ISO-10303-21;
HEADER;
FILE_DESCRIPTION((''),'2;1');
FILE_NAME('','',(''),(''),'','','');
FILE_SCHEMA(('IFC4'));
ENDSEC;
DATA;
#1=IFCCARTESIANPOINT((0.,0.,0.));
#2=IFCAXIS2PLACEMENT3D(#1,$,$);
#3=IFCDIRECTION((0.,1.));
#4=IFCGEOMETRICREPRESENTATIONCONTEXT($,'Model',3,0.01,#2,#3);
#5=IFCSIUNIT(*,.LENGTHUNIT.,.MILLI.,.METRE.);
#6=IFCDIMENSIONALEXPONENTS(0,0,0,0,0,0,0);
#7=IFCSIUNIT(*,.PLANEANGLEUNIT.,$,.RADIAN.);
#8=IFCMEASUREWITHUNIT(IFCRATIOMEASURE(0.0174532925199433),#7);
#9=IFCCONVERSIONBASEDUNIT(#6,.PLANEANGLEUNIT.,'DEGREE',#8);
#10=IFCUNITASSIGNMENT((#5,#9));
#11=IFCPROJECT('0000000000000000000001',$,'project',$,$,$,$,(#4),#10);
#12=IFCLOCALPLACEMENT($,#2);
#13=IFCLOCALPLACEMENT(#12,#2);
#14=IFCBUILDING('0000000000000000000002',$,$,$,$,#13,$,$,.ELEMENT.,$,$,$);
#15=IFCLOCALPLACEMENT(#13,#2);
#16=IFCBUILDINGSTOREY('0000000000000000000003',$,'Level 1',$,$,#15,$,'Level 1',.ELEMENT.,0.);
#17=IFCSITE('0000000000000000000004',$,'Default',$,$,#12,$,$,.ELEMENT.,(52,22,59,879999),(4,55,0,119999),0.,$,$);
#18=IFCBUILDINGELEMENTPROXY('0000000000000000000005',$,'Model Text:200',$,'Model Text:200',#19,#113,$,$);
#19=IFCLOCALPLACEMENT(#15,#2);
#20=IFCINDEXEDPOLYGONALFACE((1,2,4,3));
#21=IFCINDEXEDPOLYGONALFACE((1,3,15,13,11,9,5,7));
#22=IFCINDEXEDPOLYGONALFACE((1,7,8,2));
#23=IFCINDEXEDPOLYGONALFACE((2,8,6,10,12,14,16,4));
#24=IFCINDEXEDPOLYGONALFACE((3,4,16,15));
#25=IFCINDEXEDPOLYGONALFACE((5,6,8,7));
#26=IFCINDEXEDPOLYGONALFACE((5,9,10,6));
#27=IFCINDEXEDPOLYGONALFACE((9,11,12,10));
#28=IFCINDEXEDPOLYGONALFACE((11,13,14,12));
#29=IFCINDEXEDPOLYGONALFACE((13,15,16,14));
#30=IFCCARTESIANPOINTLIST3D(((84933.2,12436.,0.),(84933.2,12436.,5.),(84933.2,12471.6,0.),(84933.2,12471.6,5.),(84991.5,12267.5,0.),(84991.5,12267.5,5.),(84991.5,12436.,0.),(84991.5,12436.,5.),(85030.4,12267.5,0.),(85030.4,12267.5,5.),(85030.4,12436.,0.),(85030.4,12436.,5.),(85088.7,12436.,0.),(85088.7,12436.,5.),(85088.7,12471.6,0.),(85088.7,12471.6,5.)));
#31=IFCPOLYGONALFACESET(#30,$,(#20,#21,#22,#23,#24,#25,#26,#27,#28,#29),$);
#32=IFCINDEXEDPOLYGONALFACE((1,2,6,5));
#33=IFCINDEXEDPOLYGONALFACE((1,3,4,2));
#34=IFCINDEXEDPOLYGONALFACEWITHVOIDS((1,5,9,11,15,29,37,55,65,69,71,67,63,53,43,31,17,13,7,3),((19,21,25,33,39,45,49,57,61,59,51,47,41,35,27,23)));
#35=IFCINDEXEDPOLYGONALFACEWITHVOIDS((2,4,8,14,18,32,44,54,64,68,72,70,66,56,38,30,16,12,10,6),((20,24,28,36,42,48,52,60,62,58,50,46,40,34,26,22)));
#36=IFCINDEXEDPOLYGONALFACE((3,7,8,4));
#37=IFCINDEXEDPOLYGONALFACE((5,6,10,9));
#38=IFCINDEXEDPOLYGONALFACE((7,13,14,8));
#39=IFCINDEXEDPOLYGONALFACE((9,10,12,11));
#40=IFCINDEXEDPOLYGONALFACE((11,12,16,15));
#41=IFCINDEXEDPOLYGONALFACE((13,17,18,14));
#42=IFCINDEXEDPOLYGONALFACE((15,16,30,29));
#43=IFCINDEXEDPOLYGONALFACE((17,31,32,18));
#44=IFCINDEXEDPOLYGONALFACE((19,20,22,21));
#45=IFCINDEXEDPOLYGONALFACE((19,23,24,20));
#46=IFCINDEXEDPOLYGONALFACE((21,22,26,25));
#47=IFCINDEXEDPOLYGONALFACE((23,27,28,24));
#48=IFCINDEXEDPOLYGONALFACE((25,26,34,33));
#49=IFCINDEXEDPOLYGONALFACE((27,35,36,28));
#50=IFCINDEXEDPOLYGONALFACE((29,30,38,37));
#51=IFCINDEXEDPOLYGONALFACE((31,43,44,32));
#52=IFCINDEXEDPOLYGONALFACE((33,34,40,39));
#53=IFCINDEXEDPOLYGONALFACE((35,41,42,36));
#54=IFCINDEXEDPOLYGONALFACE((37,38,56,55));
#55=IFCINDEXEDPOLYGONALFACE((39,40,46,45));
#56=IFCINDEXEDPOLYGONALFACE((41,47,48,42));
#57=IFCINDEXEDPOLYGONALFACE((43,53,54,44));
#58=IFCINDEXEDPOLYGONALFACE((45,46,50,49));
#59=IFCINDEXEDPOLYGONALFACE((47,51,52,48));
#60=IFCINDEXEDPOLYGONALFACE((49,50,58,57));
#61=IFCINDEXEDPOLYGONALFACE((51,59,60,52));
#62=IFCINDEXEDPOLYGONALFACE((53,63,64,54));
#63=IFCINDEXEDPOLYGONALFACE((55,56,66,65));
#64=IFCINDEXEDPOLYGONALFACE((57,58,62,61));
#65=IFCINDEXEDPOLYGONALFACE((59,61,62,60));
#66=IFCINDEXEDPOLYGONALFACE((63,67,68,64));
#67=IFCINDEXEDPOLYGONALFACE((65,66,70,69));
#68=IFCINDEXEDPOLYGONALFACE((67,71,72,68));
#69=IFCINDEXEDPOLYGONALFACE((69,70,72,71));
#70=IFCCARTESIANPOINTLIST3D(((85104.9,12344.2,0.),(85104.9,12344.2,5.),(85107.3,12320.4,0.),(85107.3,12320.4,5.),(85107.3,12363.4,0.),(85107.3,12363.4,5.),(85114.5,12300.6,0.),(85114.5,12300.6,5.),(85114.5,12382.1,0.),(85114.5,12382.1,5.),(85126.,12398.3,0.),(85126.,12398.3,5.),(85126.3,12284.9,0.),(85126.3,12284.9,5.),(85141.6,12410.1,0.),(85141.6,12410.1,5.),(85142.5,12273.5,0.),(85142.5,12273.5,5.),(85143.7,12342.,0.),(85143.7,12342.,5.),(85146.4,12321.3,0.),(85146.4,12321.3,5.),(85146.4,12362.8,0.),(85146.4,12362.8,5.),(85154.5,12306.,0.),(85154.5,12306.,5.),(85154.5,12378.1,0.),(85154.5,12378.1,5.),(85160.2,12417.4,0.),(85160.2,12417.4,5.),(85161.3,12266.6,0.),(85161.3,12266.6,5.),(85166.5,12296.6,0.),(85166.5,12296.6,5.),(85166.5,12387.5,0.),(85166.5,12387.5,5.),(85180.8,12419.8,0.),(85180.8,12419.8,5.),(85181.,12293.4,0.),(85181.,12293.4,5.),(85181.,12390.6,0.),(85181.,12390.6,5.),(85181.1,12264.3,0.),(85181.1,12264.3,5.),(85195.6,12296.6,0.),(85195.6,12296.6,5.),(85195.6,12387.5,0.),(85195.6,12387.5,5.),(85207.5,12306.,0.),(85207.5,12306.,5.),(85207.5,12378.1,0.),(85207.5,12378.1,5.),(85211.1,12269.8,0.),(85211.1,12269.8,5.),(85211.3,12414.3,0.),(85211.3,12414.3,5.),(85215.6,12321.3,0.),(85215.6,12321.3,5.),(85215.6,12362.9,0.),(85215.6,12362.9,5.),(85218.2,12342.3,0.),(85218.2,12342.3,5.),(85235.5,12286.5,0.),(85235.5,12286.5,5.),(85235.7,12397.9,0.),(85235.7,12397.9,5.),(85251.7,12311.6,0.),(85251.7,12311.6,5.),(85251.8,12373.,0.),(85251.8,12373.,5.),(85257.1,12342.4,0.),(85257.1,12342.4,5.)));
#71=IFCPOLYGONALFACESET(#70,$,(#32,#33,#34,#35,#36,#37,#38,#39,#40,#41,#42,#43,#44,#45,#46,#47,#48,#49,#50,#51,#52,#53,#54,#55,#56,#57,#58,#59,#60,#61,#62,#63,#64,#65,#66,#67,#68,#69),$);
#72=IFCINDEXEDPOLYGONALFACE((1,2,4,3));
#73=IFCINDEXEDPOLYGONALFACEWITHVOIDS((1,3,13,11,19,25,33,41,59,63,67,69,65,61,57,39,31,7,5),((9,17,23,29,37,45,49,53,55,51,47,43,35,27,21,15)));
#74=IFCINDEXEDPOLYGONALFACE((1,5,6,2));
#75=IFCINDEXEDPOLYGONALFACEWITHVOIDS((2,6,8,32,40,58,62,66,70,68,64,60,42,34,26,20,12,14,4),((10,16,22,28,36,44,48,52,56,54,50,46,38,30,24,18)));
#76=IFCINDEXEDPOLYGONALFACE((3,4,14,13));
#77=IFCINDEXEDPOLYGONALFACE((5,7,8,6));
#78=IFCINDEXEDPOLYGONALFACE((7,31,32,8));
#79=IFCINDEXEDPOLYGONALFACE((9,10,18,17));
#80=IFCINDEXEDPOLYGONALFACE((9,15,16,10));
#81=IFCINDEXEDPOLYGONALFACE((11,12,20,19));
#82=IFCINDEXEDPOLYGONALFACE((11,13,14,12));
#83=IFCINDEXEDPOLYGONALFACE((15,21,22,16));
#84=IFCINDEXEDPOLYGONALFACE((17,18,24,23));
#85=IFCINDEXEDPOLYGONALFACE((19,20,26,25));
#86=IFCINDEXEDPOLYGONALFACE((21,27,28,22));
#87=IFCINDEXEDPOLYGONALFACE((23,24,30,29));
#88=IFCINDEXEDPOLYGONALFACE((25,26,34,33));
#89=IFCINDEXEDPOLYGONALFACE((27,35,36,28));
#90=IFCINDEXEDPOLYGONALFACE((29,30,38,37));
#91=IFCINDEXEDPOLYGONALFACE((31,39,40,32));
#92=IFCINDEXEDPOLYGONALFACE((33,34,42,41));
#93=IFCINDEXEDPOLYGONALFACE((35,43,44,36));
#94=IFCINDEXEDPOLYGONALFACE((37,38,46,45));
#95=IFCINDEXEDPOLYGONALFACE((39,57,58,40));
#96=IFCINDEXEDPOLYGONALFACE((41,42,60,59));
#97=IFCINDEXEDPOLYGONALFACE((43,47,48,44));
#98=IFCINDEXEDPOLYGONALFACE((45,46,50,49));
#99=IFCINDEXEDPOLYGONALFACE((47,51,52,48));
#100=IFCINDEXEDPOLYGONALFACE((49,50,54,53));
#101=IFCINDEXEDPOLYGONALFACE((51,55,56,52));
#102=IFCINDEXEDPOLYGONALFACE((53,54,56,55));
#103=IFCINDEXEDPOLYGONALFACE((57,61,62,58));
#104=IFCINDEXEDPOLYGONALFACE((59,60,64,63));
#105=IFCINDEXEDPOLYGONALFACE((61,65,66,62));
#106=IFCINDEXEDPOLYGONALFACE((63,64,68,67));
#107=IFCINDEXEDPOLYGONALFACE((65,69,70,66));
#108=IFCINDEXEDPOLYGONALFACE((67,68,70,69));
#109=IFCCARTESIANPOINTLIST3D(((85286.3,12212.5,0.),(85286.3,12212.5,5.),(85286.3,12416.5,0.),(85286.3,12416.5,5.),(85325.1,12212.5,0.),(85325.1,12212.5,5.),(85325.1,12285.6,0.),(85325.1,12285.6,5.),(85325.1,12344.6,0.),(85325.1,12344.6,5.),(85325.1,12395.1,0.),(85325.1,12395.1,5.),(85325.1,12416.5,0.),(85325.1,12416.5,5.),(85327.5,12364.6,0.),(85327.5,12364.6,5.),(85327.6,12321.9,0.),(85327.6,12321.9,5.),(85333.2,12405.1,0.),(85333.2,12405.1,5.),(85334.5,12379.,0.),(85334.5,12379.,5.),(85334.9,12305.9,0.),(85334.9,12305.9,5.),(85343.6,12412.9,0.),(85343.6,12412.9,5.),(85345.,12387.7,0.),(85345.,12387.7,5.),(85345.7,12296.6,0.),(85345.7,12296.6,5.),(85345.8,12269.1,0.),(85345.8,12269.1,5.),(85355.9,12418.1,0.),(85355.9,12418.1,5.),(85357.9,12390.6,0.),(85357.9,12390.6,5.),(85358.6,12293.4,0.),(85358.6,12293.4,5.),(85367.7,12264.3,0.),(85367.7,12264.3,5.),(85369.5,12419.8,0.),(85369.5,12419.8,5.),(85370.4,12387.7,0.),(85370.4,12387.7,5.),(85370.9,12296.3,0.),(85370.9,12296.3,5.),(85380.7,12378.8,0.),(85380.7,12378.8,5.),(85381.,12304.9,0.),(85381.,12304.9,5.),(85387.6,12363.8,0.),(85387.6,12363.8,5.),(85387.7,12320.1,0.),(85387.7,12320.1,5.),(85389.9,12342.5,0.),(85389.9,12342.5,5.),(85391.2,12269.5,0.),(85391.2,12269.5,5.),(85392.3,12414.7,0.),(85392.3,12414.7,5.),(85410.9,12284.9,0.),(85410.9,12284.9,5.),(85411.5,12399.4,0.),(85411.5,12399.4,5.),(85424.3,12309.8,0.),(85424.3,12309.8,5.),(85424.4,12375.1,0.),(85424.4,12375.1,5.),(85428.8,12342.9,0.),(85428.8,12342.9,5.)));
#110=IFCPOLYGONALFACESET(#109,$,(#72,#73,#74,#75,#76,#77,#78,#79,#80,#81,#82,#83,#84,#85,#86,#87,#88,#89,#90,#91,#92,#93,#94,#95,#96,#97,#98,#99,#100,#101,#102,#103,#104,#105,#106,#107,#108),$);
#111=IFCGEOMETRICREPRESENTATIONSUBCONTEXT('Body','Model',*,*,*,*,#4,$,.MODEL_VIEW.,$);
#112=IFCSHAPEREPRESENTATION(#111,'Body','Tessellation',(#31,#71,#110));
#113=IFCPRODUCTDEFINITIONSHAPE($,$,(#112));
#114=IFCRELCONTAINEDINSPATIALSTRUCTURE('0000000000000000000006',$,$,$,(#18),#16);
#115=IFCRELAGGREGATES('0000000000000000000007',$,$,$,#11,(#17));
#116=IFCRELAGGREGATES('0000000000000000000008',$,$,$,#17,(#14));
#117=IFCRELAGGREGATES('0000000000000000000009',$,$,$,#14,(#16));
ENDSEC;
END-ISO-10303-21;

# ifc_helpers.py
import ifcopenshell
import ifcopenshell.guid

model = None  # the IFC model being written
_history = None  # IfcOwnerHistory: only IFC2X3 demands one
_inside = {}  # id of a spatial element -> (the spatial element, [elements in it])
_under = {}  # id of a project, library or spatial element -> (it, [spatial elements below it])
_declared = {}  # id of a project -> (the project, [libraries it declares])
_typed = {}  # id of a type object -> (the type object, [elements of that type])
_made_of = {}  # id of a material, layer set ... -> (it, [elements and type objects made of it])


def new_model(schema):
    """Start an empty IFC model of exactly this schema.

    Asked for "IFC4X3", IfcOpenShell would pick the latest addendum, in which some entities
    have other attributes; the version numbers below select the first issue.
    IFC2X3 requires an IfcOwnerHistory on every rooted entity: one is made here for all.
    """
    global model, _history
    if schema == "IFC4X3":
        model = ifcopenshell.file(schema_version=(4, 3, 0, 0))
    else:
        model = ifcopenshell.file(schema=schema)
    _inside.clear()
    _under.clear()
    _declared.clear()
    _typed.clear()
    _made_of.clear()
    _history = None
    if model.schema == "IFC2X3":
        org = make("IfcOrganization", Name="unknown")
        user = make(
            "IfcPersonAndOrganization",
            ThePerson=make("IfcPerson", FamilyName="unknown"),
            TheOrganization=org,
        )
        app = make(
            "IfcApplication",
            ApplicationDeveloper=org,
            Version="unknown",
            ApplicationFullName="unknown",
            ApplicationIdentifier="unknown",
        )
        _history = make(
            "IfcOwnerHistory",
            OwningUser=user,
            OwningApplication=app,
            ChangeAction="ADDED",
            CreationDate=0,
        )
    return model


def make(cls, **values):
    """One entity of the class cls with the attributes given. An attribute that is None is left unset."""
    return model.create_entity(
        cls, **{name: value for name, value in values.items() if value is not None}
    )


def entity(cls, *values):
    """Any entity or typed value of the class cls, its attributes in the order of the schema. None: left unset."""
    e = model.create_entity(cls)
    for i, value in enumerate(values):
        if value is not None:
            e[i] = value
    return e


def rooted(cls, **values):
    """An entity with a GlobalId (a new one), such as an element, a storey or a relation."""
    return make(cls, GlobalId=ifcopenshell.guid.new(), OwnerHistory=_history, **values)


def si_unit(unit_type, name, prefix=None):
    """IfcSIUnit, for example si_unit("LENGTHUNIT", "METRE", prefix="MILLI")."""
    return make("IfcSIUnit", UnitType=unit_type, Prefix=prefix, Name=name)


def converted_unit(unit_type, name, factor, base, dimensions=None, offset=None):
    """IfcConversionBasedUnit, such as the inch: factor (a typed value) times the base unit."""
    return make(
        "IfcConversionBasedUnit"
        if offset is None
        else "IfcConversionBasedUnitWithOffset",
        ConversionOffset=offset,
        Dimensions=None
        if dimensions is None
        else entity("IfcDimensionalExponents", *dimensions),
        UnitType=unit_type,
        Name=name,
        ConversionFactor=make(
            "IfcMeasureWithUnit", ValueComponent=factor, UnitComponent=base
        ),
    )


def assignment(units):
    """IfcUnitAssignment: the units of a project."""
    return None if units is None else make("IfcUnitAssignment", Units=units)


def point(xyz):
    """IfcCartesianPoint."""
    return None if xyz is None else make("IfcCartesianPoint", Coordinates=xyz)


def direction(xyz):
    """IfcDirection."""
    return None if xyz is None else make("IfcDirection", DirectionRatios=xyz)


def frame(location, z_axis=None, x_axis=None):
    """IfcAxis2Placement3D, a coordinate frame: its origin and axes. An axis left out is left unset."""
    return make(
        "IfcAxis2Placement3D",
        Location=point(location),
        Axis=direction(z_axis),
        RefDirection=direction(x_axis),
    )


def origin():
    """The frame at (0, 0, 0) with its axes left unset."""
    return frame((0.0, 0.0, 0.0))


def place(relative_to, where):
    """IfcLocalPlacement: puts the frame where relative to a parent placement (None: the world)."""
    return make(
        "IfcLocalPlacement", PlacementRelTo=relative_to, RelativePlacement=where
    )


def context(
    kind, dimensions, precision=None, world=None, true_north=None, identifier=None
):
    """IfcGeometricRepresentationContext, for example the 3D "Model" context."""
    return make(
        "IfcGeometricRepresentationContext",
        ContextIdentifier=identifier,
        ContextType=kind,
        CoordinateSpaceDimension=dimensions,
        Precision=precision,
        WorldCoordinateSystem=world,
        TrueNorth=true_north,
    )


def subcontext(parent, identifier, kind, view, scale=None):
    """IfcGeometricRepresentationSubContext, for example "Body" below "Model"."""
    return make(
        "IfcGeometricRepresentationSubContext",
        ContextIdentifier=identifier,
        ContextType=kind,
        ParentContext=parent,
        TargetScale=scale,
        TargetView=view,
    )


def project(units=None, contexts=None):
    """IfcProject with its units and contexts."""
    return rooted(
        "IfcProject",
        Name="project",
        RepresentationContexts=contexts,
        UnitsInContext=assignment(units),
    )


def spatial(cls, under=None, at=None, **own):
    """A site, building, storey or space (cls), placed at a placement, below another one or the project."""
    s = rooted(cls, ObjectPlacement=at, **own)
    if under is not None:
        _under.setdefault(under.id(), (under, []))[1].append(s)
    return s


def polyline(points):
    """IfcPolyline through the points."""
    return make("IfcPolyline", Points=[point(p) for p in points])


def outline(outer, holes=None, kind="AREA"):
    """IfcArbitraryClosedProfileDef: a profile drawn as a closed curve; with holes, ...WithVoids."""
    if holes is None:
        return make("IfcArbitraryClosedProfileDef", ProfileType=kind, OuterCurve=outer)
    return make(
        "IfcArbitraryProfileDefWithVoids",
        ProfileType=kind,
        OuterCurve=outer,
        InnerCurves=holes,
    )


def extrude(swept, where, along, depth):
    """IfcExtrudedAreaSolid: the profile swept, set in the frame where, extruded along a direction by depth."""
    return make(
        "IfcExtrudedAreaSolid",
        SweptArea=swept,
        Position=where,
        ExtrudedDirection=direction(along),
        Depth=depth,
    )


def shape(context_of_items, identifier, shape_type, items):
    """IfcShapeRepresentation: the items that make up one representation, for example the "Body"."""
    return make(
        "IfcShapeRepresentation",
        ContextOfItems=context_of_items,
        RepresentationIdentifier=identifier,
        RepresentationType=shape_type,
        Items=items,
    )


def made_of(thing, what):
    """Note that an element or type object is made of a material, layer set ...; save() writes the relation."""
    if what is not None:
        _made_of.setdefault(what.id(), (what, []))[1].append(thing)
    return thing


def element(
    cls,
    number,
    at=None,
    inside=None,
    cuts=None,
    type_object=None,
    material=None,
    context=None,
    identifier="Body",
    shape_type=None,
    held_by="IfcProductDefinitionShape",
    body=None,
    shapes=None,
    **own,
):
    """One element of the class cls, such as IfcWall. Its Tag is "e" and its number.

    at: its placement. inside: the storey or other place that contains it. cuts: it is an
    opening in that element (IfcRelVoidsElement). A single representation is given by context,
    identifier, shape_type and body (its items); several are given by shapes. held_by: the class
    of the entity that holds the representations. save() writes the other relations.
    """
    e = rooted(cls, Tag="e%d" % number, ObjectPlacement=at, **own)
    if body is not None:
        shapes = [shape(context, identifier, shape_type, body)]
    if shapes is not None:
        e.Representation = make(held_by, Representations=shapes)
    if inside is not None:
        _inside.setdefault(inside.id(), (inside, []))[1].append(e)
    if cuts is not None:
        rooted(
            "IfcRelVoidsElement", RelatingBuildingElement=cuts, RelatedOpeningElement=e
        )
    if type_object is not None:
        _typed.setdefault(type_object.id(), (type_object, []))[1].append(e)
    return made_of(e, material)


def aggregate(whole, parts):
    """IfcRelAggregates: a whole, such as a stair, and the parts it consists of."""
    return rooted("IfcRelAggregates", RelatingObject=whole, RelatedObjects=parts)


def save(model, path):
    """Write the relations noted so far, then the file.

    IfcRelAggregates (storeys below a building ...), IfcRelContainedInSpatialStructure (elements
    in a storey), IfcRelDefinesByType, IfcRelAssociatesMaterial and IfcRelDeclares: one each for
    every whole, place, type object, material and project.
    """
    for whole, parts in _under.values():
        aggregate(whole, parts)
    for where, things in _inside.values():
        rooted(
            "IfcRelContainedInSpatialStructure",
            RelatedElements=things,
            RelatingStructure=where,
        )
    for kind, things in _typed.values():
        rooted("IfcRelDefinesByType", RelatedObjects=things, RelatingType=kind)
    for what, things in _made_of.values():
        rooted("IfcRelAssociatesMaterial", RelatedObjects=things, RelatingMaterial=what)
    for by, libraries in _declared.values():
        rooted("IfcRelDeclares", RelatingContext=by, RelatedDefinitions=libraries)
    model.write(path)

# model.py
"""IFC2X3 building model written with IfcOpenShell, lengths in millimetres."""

from ifc_helpers import new_model, entity, si_unit, converted_unit, direction, frame, origin, place, context, subcontext, project, spatial, polyline, outline, extrude, element, save


model = new_model("IFC2X3")

# Units and contexts
model_context = context("Model", 3, precision=0.01, world=origin(), true_north=direction((0.0, 1.0)))
body_context = subcontext(model_context, "Body", "Model", "MODEL_VIEW")
ifc_project = project(units=[si_unit("LENGTHUNIT", "METRE", prefix="MILLI"), converted_unit("PLANEANGLEUNIT", "DEGREE", entity("IfcRatioMeasure", 0.0174532925199433), si_unit("PLANEANGLEUNIT", "RADIAN"), dimensions=[0, 0, 0, 0, 0, 0, 0])], contexts=[model_context])

# Site, building, storey
site_placement = place(None, origin())
site = spatial("IfcSite", under=ifc_project, at=site_placement, Name="Default", CompositionType="ELEMENT", RefLatitude=(52, 22, 59, 879999), RefLongitude=(4, 55, 0, 119999), RefElevation=0.0)
building_placement = place(site_placement, origin())
building = spatial("IfcBuilding", under=site, at=building_placement, CompositionType="ELEMENT")
storey_placement = place(building_placement, origin())
storey = spatial("IfcBuildingStorey", under=building, at=storey_placement, Name="Level 1", LongName="Level 1", CompositionType="ELEMENT", Elevation=0.0)

# Building element proxy
proxy_1_placement = place(building_placement, origin())
element("IfcBuildingElementProxy", 1, at=proxy_1_placement, inside=storey, Name="Model Text:200", ObjectType="Model Text:200", context=body_context, shape_type="SweptSolid", body=[
    extrude(outline(polyline([(-19.4, -135.2), (19.4, -135.2), (19.4, 33.2), (77.7, 33.2), (77.7, 68.8), (-77.7, 68.8), (-77.7, 33.2), (-19.4, 33.2), (-19.4, -135.2)])), frame((85010.9, 12402.8, 0.0)), (0.0, 0.0, 1.0), 5.0),
    extrude(outline(polyline([(-8.8, -65.7), (15.1, -65.7), (35.5, -60.5), (52.3, -50.4), (65.3, -35.4), (74.1, -17.3), (78.4, 2.1), (75.9, 32.5), (61.8, 58.5), (38.4, 77.1), (8.3, 85.6), (-22.7, 83.3), (-49.0, 69.9), (-67.8, 47.3), (-76.3, 17.5), (-76.0, -3.3), (-70.7, -22.5), (-60.5, -39.2), (-45.5, -52.3), (-27.7, -61.4), (-8.8, -65.7)]), holes=[polyline([(-2.7, -27.2), (-23.1, -22.5), (-37.5, -12.9), (-45.7, 0.0), (-47.3, 14.8), (-42.7, 28.9), (-32.2, 39.9), (-16.3, 46.3), (4.5, 46.9), (25.1, 42.1), (39.6, 32.6), (47.7, 19.7), (49.4, 5.0), (44.8, -9.2), (34.2, -20.2), (18.2, -26.7), (-2.7, -27.2)])]), frame((85171.1, 12342.1, 0.0), z_axis=(0.0, 0.0, 1.0), x_axis=(0.100608, -0.994926, 0.0)), (0.0, 0.0, 1.0), 5.0),
    extrude(outline(polyline([(-73.1, -75.4), (130.9, -75.4), (130.9, -36.6), (57.8, -36.6), (74.3, -15.9), (79.1, 6.0), (73.9, 29.5), (58.4, 49.2), (33.6, 62.6), (0.5, 67.1), (-31.8, 62.8), (-56.1, 49.8), (-71.3, 30.7), (-76.4, 7.8), (-74.7, -5.8), (-69.6, -18.1), (-61.7, -28.5), (-51.7, -36.6), (-73.1, -36.6), (-73.1, -75.4)]), holes=[polyline([(-1.2, -36.6), (-21.2, -34.2), (-35.6, -27.2), (-44.3, -16.7), (-47.2, -3.8), (-44.3, 8.7), (-35.4, 19.0), (-20.4, 25.9), (0.8, 28.2), (23.3, 26.0), (38.5, 19.3), (47.1, 9.2), (49.9, -3.1), (46.8, -16.0), (37.4, -26.8), (21.5, -34.1), (-1.2, -36.6)])]), frame((85361.7, 12343.4, 0.0), z_axis=(0.0, 0.0, 1.0), x_axis=(0.0, -1.0, 0.0)), (0.0, 0.0, 1.0), 5.0),
])

save(model, "model.ifc")
